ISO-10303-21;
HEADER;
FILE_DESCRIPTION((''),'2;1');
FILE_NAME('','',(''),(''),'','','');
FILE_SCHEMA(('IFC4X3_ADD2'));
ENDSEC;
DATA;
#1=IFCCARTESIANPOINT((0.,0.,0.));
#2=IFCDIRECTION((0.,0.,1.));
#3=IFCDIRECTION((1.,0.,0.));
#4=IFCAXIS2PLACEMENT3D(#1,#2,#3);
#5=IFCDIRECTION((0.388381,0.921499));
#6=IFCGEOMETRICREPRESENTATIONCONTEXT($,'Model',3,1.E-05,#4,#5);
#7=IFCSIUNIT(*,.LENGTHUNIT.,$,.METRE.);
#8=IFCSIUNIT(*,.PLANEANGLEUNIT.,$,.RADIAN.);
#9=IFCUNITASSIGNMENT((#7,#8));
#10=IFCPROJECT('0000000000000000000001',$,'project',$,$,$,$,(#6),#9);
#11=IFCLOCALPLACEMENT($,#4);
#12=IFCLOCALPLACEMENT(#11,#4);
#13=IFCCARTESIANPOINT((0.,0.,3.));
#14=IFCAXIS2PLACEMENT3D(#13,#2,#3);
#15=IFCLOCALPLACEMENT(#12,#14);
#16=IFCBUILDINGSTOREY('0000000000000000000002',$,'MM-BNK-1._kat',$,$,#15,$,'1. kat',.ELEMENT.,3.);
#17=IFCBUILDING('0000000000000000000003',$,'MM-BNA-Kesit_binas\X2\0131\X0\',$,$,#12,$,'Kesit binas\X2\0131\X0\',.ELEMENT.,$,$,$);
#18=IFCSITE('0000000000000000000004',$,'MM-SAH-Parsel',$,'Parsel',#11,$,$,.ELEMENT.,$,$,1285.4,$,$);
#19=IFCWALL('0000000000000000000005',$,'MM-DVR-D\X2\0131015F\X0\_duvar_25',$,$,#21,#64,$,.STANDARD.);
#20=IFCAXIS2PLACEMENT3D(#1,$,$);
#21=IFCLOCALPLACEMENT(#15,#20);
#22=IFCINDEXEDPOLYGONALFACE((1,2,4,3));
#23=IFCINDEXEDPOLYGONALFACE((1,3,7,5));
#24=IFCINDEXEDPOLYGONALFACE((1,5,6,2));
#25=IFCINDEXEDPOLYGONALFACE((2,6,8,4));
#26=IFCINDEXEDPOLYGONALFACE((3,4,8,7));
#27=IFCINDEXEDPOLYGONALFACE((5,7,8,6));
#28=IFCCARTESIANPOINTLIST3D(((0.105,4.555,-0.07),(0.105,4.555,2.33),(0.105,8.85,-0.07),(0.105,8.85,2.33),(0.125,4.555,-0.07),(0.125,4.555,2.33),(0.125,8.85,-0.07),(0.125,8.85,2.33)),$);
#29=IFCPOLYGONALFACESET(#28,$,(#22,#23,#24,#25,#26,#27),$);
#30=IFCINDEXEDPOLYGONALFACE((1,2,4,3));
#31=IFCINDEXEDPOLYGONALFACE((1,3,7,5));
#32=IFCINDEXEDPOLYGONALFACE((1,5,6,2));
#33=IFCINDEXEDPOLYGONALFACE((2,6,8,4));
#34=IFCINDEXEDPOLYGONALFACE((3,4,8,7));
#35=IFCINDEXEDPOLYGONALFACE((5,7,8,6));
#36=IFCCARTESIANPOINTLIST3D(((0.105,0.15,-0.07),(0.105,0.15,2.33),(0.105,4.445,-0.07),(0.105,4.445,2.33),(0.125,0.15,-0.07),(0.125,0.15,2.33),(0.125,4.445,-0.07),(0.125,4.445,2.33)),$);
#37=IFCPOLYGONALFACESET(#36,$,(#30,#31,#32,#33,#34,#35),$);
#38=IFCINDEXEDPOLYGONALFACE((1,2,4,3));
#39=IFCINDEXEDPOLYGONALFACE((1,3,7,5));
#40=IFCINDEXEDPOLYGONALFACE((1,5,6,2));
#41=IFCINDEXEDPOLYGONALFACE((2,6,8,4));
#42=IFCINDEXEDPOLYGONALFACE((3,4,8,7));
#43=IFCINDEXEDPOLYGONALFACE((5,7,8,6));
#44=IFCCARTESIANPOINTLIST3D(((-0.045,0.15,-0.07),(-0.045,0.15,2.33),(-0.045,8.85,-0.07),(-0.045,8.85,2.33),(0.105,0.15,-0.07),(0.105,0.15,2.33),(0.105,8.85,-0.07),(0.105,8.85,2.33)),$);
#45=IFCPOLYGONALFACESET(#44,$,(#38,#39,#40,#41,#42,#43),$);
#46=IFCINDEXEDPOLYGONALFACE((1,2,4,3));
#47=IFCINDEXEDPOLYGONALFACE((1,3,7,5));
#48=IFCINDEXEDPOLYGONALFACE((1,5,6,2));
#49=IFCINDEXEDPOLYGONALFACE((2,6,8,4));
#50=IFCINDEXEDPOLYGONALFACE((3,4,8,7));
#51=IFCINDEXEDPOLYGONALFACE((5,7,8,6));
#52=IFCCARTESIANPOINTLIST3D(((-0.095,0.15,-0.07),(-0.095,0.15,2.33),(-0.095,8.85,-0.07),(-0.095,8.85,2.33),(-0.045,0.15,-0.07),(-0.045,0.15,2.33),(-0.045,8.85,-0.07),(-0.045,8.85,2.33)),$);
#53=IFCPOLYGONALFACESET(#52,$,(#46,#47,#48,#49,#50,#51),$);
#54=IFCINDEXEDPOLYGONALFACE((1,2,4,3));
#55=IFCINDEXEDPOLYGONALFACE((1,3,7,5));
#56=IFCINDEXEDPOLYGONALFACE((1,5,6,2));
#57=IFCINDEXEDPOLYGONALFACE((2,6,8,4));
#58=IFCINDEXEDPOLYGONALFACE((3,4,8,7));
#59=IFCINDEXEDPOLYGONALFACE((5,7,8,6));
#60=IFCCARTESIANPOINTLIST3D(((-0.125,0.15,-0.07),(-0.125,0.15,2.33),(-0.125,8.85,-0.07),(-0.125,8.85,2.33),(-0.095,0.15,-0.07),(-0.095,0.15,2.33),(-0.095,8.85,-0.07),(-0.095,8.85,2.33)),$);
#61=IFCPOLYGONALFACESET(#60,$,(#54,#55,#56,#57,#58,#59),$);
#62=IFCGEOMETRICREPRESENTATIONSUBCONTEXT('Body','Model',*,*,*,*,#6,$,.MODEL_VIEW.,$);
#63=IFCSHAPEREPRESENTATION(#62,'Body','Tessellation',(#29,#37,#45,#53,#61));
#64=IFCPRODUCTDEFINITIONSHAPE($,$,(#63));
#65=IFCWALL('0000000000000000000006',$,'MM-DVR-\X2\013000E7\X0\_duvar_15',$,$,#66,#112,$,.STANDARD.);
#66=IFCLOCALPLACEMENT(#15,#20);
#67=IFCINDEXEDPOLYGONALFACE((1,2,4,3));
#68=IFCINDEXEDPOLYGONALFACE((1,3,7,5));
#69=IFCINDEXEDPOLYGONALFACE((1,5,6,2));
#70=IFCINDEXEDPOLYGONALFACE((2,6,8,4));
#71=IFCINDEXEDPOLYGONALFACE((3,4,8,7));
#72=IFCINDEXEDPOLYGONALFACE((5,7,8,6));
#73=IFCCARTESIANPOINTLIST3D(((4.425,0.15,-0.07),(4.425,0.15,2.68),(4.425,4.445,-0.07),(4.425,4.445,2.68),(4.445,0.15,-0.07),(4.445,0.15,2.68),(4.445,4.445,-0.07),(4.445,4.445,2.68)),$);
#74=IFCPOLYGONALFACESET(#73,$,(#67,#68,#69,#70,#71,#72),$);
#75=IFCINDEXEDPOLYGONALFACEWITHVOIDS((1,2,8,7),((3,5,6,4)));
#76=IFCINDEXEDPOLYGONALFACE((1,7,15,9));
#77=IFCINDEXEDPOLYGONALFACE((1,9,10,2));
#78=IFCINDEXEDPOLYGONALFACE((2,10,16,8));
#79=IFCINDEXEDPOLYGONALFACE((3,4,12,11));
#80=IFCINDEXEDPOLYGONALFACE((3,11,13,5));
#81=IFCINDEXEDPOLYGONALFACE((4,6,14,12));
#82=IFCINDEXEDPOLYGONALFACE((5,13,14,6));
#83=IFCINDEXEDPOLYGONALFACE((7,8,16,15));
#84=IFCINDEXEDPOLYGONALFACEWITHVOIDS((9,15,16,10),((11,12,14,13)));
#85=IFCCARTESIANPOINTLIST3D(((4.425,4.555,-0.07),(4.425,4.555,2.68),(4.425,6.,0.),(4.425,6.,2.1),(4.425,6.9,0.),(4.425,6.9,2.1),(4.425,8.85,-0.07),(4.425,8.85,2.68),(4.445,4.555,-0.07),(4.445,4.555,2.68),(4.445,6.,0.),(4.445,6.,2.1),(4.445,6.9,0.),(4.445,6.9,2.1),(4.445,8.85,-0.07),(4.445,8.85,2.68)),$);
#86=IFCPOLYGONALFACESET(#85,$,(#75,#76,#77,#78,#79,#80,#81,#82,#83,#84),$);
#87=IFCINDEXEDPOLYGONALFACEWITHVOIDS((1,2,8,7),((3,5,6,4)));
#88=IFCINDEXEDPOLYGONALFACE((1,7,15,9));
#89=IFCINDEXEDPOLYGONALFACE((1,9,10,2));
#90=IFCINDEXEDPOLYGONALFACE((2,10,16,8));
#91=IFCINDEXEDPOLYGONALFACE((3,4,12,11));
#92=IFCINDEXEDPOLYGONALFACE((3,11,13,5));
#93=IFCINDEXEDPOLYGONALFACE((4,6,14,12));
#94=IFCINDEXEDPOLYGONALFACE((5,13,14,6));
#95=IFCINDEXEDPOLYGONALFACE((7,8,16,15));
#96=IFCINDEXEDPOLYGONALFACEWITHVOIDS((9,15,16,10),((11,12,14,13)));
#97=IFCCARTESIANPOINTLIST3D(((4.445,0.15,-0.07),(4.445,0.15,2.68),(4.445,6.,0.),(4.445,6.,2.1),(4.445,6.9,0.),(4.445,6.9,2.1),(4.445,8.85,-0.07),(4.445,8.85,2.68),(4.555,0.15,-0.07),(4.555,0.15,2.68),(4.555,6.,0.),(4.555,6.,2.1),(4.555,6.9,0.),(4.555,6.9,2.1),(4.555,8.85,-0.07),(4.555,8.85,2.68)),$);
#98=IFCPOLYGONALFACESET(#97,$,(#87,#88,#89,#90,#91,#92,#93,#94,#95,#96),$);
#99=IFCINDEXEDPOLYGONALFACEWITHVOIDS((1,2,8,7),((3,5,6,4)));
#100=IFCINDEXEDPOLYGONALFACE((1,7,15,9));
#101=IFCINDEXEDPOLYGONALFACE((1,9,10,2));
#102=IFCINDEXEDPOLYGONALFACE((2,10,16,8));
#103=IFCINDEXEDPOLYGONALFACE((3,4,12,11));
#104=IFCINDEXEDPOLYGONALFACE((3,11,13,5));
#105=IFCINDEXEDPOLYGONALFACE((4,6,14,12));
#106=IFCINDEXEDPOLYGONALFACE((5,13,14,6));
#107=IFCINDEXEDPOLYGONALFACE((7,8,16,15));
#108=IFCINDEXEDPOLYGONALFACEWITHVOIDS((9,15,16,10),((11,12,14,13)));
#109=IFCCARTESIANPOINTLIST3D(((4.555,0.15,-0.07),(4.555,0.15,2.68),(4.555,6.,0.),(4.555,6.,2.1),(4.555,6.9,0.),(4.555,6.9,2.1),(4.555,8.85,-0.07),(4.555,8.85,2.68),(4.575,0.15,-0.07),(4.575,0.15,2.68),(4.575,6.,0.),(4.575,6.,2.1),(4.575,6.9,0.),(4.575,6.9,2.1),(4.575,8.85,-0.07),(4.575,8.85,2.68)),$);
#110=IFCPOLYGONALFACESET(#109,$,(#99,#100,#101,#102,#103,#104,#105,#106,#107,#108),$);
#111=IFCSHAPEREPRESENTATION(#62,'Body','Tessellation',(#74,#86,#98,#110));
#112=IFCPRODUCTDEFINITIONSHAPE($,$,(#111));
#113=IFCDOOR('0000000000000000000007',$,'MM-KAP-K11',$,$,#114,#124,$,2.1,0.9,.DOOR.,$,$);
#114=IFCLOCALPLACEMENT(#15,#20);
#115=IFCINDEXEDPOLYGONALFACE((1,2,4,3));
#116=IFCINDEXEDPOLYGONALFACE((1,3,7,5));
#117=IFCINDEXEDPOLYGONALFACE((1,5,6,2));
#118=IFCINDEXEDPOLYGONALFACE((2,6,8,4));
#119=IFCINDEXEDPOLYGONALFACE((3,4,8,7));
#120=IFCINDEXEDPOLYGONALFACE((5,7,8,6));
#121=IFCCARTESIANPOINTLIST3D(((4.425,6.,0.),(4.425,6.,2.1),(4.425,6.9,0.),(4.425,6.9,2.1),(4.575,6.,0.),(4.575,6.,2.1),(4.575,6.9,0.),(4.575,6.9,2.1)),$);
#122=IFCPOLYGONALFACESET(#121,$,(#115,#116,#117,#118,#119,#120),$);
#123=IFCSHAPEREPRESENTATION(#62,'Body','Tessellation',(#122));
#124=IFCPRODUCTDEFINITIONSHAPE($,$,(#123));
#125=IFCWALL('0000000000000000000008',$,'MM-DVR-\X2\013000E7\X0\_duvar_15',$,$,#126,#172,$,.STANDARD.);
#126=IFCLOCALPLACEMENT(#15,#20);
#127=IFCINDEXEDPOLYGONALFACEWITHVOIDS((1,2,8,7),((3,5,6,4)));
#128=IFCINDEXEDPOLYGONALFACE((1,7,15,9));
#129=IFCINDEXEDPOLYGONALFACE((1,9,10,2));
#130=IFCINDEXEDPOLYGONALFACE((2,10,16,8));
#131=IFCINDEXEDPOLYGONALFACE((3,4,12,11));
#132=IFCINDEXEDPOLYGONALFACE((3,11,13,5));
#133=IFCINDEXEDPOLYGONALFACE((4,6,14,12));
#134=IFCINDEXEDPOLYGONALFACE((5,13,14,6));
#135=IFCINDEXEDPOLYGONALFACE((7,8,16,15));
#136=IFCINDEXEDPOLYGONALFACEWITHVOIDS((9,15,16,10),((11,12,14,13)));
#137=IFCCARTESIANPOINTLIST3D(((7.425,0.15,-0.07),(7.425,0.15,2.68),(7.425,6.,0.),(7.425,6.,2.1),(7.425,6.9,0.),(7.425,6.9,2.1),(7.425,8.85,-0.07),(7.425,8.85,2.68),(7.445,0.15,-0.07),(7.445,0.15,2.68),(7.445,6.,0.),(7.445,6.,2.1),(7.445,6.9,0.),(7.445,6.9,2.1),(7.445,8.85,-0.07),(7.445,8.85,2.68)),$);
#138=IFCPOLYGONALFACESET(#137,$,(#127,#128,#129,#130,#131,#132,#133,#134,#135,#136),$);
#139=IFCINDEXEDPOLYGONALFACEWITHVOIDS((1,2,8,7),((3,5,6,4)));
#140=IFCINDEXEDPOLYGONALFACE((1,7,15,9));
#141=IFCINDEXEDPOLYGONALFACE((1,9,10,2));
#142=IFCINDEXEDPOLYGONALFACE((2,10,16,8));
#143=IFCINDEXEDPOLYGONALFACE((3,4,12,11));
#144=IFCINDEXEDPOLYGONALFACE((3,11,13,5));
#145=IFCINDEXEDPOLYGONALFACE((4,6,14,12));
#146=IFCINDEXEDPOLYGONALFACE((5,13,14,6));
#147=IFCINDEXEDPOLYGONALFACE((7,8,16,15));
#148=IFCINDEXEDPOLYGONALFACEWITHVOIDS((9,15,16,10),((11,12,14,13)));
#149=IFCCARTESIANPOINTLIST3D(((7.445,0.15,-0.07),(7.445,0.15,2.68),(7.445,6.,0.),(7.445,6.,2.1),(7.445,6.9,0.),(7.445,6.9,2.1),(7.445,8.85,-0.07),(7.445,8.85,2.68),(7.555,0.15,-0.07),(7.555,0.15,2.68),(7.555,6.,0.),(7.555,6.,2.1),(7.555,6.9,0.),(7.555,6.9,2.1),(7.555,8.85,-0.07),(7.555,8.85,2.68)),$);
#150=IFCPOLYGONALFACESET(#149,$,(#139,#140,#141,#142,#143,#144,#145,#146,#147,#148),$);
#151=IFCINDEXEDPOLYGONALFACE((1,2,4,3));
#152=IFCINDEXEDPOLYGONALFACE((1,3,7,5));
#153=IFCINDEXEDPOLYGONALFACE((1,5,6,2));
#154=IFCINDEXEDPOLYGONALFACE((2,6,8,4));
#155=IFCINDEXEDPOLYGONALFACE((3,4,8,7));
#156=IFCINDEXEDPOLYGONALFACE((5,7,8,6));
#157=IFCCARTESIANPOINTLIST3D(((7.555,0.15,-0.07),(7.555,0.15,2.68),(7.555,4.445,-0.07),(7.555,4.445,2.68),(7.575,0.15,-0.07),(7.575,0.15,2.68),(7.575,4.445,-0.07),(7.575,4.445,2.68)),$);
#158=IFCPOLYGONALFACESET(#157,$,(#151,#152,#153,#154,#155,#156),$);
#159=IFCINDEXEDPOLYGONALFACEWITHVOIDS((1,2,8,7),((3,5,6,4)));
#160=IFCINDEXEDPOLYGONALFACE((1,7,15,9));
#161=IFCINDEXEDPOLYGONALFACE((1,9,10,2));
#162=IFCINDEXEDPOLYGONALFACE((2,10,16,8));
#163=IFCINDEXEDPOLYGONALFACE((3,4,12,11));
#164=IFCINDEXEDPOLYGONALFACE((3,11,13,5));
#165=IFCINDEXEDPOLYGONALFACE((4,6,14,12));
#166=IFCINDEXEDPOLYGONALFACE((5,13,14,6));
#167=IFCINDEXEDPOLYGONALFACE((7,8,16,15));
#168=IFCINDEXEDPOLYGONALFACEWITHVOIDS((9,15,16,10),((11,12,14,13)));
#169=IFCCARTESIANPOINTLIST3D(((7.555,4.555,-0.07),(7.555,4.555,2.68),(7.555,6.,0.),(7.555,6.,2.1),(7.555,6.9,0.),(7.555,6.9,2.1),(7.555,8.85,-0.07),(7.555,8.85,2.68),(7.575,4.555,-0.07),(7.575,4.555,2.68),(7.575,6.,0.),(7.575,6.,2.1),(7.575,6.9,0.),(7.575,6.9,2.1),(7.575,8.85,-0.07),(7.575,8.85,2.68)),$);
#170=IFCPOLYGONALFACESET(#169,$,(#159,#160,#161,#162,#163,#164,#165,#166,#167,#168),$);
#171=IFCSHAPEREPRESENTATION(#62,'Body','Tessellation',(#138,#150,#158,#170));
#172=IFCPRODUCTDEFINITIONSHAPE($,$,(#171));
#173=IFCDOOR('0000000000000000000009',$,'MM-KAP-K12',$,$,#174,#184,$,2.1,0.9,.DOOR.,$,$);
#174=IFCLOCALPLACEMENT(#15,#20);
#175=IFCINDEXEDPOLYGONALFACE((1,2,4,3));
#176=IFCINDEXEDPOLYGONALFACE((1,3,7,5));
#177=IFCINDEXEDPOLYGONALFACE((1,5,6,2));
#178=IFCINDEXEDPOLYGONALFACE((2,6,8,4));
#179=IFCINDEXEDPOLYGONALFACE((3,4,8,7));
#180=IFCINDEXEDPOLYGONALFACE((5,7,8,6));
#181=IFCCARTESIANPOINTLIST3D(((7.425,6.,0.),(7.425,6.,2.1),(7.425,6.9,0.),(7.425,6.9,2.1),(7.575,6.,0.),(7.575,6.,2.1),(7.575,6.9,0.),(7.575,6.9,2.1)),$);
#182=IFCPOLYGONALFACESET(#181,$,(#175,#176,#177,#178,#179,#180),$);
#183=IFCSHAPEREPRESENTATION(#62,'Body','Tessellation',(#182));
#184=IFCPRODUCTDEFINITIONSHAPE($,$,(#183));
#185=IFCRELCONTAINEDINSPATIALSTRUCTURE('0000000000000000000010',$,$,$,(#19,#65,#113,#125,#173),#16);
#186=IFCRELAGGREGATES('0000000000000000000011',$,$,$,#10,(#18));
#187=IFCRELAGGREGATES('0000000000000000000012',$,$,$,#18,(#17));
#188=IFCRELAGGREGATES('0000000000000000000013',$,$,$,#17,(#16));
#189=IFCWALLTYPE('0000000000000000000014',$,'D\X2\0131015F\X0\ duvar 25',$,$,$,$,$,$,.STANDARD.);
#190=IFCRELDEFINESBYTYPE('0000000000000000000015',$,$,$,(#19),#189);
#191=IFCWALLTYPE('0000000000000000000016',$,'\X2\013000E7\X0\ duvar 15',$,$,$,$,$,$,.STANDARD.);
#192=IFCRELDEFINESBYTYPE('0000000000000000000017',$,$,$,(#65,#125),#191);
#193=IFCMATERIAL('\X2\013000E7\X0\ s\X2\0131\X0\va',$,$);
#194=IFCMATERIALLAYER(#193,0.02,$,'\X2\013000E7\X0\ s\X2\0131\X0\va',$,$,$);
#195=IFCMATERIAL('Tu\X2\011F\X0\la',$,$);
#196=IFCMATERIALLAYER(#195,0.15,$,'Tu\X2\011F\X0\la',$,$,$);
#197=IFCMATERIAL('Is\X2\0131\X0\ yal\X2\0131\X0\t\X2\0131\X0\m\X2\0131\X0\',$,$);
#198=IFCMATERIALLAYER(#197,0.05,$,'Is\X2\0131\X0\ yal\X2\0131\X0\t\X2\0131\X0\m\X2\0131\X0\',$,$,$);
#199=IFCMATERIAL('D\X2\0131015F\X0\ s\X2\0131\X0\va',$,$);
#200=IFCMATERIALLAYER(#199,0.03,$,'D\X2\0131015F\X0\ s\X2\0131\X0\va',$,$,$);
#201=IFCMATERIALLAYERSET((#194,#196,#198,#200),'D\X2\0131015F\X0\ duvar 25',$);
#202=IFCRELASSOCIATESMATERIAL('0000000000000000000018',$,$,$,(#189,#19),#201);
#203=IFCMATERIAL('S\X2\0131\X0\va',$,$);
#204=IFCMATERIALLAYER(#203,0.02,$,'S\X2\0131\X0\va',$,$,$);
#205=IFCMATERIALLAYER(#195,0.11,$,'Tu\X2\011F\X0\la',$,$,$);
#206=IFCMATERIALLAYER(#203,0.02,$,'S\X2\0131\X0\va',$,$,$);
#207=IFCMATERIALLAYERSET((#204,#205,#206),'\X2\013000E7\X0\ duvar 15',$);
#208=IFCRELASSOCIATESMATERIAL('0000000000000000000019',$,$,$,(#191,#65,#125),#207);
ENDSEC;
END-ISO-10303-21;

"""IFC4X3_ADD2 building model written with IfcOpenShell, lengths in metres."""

from ifc_helpers import new_model, si_unit, direction, frame, origin, origin_with_axes, place, context, subcontext, project, spatial, polyline, outline, extrude, material, layer, layer_set, type_object, element, fill, save


model = new_model("IFC4X3_ADD2")

# Units and contexts
model_context = context("Model", 3, precision=1e-05, world=origin_with_axes(), true_north=direction((0.388381, 0.921499)))
body_context = subcontext(model_context, "Body", "Model", "MODEL_VIEW")
ifc_project = project(units=[si_unit("LENGTHUNIT", "METRE"), si_unit("PLANEANGLEUNIT", "RADIAN")], contexts=[model_context])

# Site, building, storey
site_placement = place(None, origin_with_axes())
site = spatial("IfcSite", under=ifc_project, at=site_placement, Name="MM-SAH-Parsel", ObjectType="Parsel", CompositionType="ELEMENT", RefElevation=1285.4)
building_placement = place(site_placement, origin_with_axes())
building = spatial("IfcBuilding", under=site, at=building_placement, Name="MM-BNA-Kesit_binası", LongName="Kesit binası", CompositionType="ELEMENT")
storey_placement = place(building_placement, frame((0.0, 0.0, 3.0), z_axis=(0.0, 0.0, 1.0), x_axis=(1.0, 0.0, 0.0)))
storey = spatial("IfcBuildingStorey", under=building, at=storey_placement, Name="MM-BNK-1._kat", LongName="1. kat", CompositionType="ELEMENT", Elevation=3.0)

# Shared definitions
ifc_material_1 = material(Name="İç sıva")
ifc_layer_1 = layer(ifc_material_1, 0.02, Name="İç sıva")
ifc_material_2 = material(Name="Tuğla")
ifc_layer_2 = layer(ifc_material_2, 0.15, Name="Tuğla")
ifc_material_3 = material(Name="Isı yalıtımı")
ifc_layer_3 = layer(ifc_material_3, 0.05, Name="Isı yalıtımı")
ifc_material_4 = material(Name="Dış sıva")
ifc_layer_4 = layer(ifc_material_4, 0.03, Name="Dış sıva")
ifc_layer_set_1 = layer_set([ifc_layer_1, ifc_layer_2, ifc_layer_3, ifc_layer_4], Name="Dış duvar 25")
wall_type_1 = type_object("IfcWallType", Name="Dış duvar 25", PredefinedType="STANDARD", material=ifc_layer_set_1)

# Wall
wall_1_placement = place(storey_placement, origin_with_axes())
element("IfcWall", 1, at=wall_1_placement, inside=storey, type_object=wall_type_1, material=ifc_layer_set_1, Name="MM-DVR-Dış_duvar_25", PredefinedType="STANDARD", context=body_context, shape_type="SweptSolid", body=[
    extrude(outline(polyline([(0.105, 8.85), (0.105, 4.555), (0.125, 4.555), (0.125, 8.85), (0.105, 8.85)])), frame((0.0, 0.0, -0.07)), (0.0, 0.0, 1.0), 2.4),
    extrude(outline(polyline([(0.105, 4.445), (0.105, 0.15), (0.125, 0.15), (0.125, 4.445), (0.105, 4.445)])), frame((0.0, 0.0, -0.07)), (0.0, 0.0, 1.0), 2.4),
    extrude(outline(polyline([(-0.045, 8.85), (-0.045, 0.15), (0.105, 0.15), (0.105, 8.85), (-0.045, 8.85)])), frame((0.0, 0.0, -0.07)), (0.0, 0.0, 1.0), 2.4),
    extrude(outline(polyline([(-0.095, 8.85), (-0.095, 0.15), (-0.045, 0.15), (-0.045, 8.85), (-0.095, 8.85)])), frame((0.0, 0.0, -0.07)), (0.0, 0.0, 1.0), 2.4),
    extrude(outline(polyline([(-0.125, 8.85), (-0.125, 0.15), (-0.095, 0.15), (-0.095, 8.85), (-0.125, 8.85)])), frame((0.0, 0.0, -0.07)), (0.0, 0.0, 1.0), 2.4),
])

# Walls, openings, doors
ifc_material_5 = material(Name="Sıva")
ifc_layer_5 = layer(ifc_material_5, 0.02, Name="Sıva")
ifc_layer_6 = layer(ifc_material_2, 0.11, Name="Tuğla")
ifc_layer_7 = layer(ifc_material_5, 0.02, Name="Sıva")
ifc_layer_set_2 = layer_set([ifc_layer_5, ifc_layer_6, ifc_layer_7], Name="İç duvar 15")
wall_type_2 = type_object("IfcWallType", Name="İç duvar 15", PredefinedType="STANDARD", material=ifc_layer_set_2)
wall_2_placement = place(storey_placement, origin_with_axes())
wall_2 = element("IfcWall", 2, at=wall_2_placement, inside=storey, type_object=wall_type_2, material=ifc_layer_set_2, Name="MM-DVR-İç_duvar_15", PredefinedType="STANDARD", context=body_context, shape_type="SweptSolid", body=[
    extrude(outline(polyline([(4.445, 0.15), (4.445, 4.445), (4.425, 4.445), (4.425, 0.15), (4.445, 0.15)])), frame((0.0, 0.0, -0.07)), (0.0, 0.0, 1.0), 2.75),
    extrude(outline(polyline([(4.445, 4.555), (4.445, 8.85), (4.425, 8.85), (4.425, 4.555), (4.445, 4.555)])), frame((0.0, 0.0, -0.07)), (0.0, 0.0, 1.0), 2.75),
    extrude(outline(polyline([(4.555, 0.15), (4.555, 8.85), (4.445, 8.85), (4.445, 0.15), (4.555, 0.15)])), frame((0.0, 0.0, -0.07)), (0.0, 0.0, 1.0), 2.75),
    extrude(outline(polyline([(4.575, 0.15), (4.575, 8.85), (4.555, 8.85), (4.555, 0.15), (4.575, 0.15)])), frame((0.0, 0.0, -0.07)), (0.0, 0.0, 1.0), 2.75),
])
opening_1_placement = place(storey_placement, origin_with_axes())
opening_1 = element("IfcOpeningElement", 3, at=opening_1_placement, cuts=wall_2, PredefinedType="OPENING", context=body_context, shape_type="SweptSolid", body=[
    extrude(outline(polyline([(4.425, 6.0), (4.425, 6.9), (4.575, 6.9), (4.575, 6.0), (4.425, 6.0)])), origin(), (0.0, 0.0, 1.0), 2.1),
])
door_1_placement = place(storey_placement, origin_with_axes())
door_1 = element("IfcDoor", 4, at=door_1_placement, inside=storey, Name="MM-KAP-K11", OverallHeight=2.1, OverallWidth=0.9, PredefinedType="DOOR", context=body_context, shape_type="SweptSolid", body=[
    extrude(outline(polyline([(4.425, 6.0), (4.425, 6.9), (4.575, 6.9), (4.575, 6.0), (4.425, 6.0)])), origin(), (0.0, 0.0, 1.0), 2.1),
])
fill(opening_1, door_1)
wall_3_placement = place(storey_placement, origin_with_axes())
wall_3 = element("IfcWall", 5, at=wall_3_placement, inside=storey, type_object=wall_type_2, material=ifc_layer_set_2, Name="MM-DVR-İç_duvar_15", PredefinedType="STANDARD", context=body_context, shape_type="SweptSolid", body=[
    extrude(outline(polyline([(7.445, 0.15), (7.445, 8.85), (7.425, 8.85), (7.425, 0.15), (7.445, 0.15)])), frame((0.0, 0.0, -0.07)), (0.0, 0.0, 1.0), 2.75),
    extrude(outline(polyline([(7.555, 0.15), (7.555, 8.85), (7.445, 8.85), (7.445, 0.15), (7.555, 0.15)])), frame((0.0, 0.0, -0.07)), (0.0, 0.0, 1.0), 2.75),
    extrude(outline(polyline([(7.575, 0.15), (7.575, 4.445), (7.555, 4.445), (7.555, 0.15), (7.575, 0.15)])), frame((0.0, 0.0, -0.07)), (0.0, 0.0, 1.0), 2.75),
    extrude(outline(polyline([(7.575, 4.555), (7.575, 8.85), (7.555, 8.85), (7.555, 4.555), (7.575, 4.555)])), frame((0.0, 0.0, -0.07)), (0.0, 0.0, 1.0), 2.75),
])
opening_2_placement = place(storey_placement, origin_with_axes())
opening_2 = element("IfcOpeningElement", 6, at=opening_2_placement, cuts=wall_3, PredefinedType="OPENING", context=body_context, shape_type="SweptSolid", body=[
    extrude(outline(polyline([(7.425, 6.0), (7.425, 6.9), (7.575, 6.9), (7.575, 6.0), (7.425, 6.0)])), origin(), (0.0, 0.0, 1.0), 2.1),
])
door_2_placement = place(storey_placement, origin_with_axes())
door_2 = element("IfcDoor", 7, at=door_2_placement, inside=storey, Name="MM-KAP-K12", OverallHeight=2.1, OverallWidth=0.9, PredefinedType="DOOR", context=body_context, shape_type="SweptSolid", body=[
    extrude(outline(polyline([(7.425, 6.0), (7.425, 6.9), (7.575, 6.9), (7.575, 6.0), (7.425, 6.0)])), origin(), (0.0, 0.0, 1.0), 2.1),
])
fill(opening_2, door_2)

save(model, "model.ifc")
